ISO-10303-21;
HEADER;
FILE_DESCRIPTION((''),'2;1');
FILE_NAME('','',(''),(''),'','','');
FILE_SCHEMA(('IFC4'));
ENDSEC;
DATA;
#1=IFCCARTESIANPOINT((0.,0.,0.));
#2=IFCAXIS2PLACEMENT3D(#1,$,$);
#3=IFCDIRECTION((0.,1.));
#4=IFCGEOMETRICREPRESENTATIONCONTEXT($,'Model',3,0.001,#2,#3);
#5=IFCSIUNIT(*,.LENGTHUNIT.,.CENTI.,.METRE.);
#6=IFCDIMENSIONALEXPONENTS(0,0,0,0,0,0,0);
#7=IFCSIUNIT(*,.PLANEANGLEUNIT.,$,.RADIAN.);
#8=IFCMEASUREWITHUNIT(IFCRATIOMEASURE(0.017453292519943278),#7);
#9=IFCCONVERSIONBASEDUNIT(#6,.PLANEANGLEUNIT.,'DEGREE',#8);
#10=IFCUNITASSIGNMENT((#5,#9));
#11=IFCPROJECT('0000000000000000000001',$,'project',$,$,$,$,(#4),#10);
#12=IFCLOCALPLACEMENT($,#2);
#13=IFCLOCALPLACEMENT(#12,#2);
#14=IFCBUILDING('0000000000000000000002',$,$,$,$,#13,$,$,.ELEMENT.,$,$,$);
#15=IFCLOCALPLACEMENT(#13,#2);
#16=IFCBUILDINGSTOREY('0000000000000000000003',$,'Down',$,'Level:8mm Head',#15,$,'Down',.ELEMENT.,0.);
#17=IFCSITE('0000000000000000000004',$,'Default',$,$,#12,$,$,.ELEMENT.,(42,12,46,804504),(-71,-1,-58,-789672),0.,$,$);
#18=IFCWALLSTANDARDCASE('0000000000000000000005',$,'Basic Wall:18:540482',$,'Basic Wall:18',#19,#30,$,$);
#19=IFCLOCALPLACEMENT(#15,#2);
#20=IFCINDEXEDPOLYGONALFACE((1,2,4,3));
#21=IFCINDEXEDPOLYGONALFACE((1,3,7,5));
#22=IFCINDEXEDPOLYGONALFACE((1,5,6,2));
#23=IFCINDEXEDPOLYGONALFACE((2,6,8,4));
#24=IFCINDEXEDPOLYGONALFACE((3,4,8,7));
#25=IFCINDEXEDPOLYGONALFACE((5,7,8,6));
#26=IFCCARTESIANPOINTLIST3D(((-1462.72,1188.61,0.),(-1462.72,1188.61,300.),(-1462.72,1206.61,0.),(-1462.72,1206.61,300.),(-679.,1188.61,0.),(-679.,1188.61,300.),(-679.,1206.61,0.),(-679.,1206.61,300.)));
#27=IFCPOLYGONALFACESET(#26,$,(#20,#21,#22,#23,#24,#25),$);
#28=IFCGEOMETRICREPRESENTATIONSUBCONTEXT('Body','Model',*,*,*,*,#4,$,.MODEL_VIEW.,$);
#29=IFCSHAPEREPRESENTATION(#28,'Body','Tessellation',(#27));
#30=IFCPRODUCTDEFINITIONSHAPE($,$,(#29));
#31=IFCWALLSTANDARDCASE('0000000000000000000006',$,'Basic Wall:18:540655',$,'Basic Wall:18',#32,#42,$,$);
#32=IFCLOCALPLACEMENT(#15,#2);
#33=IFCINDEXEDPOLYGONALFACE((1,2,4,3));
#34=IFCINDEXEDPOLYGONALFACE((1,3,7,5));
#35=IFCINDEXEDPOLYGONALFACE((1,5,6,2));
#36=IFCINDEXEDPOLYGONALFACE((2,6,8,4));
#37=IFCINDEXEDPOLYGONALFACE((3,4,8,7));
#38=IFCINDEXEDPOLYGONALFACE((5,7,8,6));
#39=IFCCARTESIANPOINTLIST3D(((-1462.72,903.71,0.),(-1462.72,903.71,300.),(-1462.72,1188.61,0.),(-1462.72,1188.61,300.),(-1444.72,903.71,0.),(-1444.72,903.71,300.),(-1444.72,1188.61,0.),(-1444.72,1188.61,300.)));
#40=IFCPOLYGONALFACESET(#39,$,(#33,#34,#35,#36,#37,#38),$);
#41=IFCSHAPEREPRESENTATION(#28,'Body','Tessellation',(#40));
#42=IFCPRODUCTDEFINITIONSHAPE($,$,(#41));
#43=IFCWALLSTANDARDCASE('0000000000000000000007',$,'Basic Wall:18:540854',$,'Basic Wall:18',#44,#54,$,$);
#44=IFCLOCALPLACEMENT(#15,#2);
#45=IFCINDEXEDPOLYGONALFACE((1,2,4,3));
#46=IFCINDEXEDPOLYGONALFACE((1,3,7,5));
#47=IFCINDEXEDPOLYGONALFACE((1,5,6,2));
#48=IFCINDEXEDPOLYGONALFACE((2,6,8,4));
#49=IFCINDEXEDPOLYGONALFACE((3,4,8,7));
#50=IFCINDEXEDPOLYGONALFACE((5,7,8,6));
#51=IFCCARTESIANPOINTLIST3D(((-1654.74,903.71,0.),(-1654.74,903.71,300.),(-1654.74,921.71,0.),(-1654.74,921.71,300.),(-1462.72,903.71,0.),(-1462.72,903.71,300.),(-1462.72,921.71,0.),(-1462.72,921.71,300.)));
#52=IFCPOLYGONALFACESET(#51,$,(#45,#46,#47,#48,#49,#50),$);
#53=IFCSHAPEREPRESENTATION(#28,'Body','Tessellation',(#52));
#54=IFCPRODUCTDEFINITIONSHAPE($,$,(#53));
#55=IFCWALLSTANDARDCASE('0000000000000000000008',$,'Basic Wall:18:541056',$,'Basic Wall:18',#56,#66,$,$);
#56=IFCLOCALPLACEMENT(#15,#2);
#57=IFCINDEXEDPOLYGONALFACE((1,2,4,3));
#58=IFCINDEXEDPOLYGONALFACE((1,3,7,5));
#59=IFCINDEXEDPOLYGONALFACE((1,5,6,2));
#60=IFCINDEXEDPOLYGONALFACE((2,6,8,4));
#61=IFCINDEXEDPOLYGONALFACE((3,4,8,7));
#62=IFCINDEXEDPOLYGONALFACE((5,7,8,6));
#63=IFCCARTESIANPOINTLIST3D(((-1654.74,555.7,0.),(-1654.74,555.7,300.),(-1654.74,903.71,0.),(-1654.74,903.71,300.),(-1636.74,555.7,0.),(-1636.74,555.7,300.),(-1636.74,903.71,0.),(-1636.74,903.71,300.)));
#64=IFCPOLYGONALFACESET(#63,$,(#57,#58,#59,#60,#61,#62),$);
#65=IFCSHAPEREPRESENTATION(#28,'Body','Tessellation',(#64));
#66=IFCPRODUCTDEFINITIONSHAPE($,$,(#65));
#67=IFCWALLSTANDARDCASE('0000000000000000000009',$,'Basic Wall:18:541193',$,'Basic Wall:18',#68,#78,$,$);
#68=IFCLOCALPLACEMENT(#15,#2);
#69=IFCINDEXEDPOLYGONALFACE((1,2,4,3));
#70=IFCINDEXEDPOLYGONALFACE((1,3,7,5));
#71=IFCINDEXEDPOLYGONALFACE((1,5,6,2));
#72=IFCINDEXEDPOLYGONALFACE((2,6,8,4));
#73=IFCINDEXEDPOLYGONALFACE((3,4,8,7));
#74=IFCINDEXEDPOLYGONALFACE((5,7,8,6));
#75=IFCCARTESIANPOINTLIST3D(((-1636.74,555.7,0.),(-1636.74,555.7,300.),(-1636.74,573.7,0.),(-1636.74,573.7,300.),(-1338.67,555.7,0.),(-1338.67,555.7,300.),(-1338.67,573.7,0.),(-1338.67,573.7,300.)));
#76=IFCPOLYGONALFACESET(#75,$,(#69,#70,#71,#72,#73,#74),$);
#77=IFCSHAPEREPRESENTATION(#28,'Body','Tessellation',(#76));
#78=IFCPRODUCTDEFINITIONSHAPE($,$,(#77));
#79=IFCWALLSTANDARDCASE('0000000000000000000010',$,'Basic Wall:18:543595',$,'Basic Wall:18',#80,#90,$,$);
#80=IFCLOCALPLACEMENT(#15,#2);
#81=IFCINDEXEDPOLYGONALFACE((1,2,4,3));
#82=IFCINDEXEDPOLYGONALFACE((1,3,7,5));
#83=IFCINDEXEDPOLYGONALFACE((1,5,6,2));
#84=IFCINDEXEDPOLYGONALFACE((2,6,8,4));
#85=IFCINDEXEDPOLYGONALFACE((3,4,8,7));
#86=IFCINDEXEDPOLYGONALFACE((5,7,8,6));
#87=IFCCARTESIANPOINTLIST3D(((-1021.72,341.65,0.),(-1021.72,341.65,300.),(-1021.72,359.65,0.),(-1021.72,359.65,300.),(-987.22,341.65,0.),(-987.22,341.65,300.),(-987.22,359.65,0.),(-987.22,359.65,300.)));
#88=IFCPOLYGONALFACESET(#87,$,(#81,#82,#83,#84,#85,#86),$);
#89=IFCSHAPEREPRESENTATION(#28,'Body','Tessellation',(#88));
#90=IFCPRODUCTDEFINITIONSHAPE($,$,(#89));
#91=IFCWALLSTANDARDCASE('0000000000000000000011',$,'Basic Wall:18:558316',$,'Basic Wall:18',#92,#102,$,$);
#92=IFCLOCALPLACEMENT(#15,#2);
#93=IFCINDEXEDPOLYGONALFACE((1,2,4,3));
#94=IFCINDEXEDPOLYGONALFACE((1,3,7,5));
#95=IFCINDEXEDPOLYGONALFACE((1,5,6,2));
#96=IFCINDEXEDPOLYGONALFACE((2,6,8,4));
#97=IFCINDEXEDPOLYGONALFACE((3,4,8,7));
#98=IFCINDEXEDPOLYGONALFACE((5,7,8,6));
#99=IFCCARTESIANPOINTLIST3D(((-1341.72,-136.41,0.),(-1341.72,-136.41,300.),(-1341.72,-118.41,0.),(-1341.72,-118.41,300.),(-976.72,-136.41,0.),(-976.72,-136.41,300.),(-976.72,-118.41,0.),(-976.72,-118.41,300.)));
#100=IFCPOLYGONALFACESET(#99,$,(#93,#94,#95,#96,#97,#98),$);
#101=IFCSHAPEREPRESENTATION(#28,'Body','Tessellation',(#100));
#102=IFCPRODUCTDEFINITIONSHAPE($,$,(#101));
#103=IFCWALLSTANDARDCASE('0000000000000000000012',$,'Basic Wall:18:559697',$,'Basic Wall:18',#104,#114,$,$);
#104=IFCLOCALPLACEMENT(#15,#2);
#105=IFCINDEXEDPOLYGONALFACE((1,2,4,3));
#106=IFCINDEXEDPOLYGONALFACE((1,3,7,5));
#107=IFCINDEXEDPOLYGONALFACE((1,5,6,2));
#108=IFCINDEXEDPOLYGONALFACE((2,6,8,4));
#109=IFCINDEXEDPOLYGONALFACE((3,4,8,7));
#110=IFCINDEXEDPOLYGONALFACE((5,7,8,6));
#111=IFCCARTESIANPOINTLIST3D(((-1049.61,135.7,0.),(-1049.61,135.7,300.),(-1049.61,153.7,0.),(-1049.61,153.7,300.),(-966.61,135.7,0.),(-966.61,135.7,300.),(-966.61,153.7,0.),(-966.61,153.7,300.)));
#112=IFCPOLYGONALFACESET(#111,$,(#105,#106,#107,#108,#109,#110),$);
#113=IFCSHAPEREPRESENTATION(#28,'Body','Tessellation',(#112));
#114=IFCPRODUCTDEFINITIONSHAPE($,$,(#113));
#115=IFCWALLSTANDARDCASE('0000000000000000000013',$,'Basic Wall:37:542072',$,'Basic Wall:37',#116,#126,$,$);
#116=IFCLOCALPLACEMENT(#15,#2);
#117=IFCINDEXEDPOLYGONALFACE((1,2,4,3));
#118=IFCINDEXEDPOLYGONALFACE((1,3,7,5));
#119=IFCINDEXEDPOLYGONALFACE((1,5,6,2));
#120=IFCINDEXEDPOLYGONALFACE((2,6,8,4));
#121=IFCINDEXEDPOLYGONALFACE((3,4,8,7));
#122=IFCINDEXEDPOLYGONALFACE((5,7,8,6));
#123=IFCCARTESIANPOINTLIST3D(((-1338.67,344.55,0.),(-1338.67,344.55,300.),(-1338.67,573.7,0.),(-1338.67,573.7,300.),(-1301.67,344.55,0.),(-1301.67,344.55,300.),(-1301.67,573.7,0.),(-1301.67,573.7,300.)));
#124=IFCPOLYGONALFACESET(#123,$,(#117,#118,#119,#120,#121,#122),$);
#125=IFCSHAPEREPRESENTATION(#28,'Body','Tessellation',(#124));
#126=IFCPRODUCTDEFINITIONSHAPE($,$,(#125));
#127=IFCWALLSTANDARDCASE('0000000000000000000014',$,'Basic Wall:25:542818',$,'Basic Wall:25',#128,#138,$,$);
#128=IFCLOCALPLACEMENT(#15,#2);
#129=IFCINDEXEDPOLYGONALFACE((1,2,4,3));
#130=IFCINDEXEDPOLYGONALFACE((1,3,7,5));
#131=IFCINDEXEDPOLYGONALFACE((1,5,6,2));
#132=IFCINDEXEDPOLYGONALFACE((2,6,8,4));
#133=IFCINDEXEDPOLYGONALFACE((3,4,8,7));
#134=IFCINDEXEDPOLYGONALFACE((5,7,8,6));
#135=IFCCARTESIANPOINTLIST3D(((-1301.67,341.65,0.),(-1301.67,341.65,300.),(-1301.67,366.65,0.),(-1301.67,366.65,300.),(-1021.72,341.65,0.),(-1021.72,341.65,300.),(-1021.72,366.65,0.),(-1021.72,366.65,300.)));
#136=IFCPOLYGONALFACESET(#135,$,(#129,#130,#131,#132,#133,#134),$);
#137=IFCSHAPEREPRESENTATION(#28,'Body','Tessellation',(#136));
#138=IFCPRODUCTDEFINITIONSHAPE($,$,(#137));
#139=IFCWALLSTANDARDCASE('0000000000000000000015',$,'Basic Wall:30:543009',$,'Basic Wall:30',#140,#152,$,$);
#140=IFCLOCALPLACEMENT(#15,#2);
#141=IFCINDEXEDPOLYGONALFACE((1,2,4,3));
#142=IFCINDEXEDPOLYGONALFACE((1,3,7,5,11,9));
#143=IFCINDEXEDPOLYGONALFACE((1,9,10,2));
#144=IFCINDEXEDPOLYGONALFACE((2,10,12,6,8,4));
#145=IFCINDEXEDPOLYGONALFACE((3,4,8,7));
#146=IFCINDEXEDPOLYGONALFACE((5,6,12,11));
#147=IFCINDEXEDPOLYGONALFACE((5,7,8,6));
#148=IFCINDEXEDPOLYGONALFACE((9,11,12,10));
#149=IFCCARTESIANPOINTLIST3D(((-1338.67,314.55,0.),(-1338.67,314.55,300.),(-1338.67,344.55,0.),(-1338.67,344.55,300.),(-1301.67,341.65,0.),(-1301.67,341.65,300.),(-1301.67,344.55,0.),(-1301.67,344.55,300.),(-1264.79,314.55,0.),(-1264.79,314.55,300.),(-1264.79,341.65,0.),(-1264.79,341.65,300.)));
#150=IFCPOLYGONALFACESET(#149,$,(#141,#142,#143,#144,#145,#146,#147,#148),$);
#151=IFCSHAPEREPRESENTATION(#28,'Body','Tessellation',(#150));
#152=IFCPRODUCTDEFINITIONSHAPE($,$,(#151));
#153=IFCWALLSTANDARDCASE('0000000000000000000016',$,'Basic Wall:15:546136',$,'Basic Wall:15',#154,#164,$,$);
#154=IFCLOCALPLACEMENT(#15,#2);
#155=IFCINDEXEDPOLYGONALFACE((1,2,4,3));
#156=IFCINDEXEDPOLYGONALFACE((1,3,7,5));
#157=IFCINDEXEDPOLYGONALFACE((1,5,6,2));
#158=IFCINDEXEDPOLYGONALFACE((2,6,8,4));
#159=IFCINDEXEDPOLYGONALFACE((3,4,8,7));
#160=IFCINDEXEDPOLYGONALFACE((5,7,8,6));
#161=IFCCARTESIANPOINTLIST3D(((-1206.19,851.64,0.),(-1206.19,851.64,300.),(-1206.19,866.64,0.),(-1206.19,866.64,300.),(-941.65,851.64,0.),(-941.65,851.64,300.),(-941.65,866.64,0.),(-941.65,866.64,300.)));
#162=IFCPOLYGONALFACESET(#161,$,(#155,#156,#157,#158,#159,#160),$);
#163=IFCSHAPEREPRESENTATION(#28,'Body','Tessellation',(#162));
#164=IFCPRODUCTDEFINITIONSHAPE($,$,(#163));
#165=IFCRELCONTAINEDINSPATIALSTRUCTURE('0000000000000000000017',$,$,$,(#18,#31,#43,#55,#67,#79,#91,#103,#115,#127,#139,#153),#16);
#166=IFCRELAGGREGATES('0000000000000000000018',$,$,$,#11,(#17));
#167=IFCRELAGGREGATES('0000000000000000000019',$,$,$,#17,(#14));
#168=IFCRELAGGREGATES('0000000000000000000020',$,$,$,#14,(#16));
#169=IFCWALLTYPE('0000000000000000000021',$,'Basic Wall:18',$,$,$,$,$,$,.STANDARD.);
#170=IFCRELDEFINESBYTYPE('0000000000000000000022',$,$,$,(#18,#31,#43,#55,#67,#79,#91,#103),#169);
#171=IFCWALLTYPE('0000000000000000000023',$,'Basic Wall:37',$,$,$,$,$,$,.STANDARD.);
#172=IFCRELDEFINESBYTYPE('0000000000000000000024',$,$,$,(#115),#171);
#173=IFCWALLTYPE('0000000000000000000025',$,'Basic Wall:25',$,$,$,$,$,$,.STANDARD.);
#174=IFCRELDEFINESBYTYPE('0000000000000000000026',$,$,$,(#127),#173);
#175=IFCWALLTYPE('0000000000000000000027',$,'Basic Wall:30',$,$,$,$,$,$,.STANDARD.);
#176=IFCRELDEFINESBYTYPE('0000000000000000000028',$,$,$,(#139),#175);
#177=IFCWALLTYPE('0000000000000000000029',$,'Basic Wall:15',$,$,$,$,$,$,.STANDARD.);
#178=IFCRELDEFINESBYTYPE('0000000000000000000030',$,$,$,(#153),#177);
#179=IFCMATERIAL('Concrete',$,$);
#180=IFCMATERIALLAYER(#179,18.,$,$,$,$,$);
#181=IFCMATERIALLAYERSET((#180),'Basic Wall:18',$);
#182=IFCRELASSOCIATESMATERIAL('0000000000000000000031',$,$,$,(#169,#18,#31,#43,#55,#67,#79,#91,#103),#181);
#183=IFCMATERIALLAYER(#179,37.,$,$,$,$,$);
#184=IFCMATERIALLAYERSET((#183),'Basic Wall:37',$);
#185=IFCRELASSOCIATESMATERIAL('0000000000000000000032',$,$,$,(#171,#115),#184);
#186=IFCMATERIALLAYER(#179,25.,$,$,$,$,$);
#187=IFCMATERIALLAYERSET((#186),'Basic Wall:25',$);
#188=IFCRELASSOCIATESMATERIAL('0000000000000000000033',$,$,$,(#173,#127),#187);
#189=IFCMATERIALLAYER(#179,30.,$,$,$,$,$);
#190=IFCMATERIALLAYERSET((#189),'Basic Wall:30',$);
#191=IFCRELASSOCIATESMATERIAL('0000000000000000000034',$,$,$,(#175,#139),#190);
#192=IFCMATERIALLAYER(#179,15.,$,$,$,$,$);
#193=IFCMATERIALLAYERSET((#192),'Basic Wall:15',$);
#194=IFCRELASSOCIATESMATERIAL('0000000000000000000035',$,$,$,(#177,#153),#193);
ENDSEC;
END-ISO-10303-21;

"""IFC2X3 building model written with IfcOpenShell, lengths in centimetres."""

from ifc_helpers import new_model, entity, si_unit, converted_unit, direction, frame, frame_2d, origin, place, context, subcontext, project, spatial, polyline, rectangle, extrude, clip, bounded_halfspace, material, layer, layer_set, layer_usage, type_object, element, save


model = new_model("IFC2X3")

# Units and contexts
model_context = context("Model", 3, precision=0.001, world=origin(), true_north=direction((0.0, 1.0)))
body_context = subcontext(model_context, "Body", "Model", "MODEL_VIEW")
ifc_project = project(units=[si_unit("LENGTHUNIT", "METRE", prefix="CENTI"), converted_unit("PLANEANGLEUNIT", "DEGREE", entity("IfcRatioMeasure", 0.017453292519943278), si_unit("PLANEANGLEUNIT", "RADIAN"), dimensions=[0, 0, 0, 0, 0, 0, 0])], contexts=[model_context])

# Site, building, storey
site_placement = place(None, origin())
site = spatial("IfcSite", under=ifc_project, at=site_placement, Name="Default", CompositionType="ELEMENT", RefLatitude=(42, 12, 46, 804504), RefLongitude=(-71, -1, -58, -789672), RefElevation=0.0)
building_placement = place(site_placement, origin())
building = spatial("IfcBuilding", under=site, at=building_placement, CompositionType="ELEMENT")
storey_placement = place(building_placement, origin())
storey = spatial("IfcBuildingStorey", under=building, at=storey_placement, Name="Down", ObjectType="Level:8mm Head", LongName="Down", CompositionType="ELEMENT", Elevation=0.0)

# Walls
ifc_material = material(Name="Concrete")
ifc_layer_1 = layer(ifc_material, 18.0)
ifc_layer_set_1 = layer_set([ifc_layer_1], Name="Basic Wall:18")
wall_type_1 = type_object("IfcWallType", Name="Basic Wall:18", PredefinedType="STANDARD", material=ifc_layer_set_1)
ifc_layer_usage_1 = layer_usage(ifc_layer_set_1, "AXIS2", "POSITIVE", -9.0)
wall_1_placement = place(storey_placement, frame((-679.0, 1197.61, 0.0), z_axis=(0.0, 0.0, 1.0), x_axis=(-1.0, 0.0, 0.0)))
element("IfcWallStandardCase", 1, at=wall_1_placement, inside=storey, type_object=wall_type_1, material=ifc_layer_usage_1, Name="Basic Wall:18:540482", ObjectType="Basic Wall:18", context=body_context, shape_type="SweptSolid", body=[
    extrude(rectangle(XDim=783.71, YDim=18.0, at=frame_2d((391.86, 0.0), x_axis=(-1.0, 0.0))), origin(), (0.0, 0.0, 1.0), 300.0),
])
ifc_layer_usage_2 = layer_usage(ifc_layer_set_1, "AXIS2", "POSITIVE", -9.0)
wall_2_placement = place(storey_placement, frame((-1453.72, 1188.61, 0.0), z_axis=(0.0, 0.0, 1.0), x_axis=(0.0, -1.0, 0.0)))
element("IfcWallStandardCase", 2, at=wall_2_placement, inside=storey, type_object=wall_type_1, material=ifc_layer_usage_2, Name="Basic Wall:18:540655", ObjectType="Basic Wall:18", context=body_context, shape_type="SweptSolid", body=[
    extrude(rectangle(XDim=284.9, YDim=18.0, at=frame_2d((142.45, 0.0), x_axis=(-1.0, 0.0))), origin(), (0.0, 0.0, 1.0), 300.0),
])
ifc_layer_usage_3 = layer_usage(ifc_layer_set_1, "AXIS2", "NEGATIVE", 9.0)
wall_3_placement = place(storey_placement, frame((-1462.72, 912.71, 0.0), z_axis=(0.0, 0.0, 1.0), x_axis=(-1.0, 0.0, 0.0)))
element("IfcWallStandardCase", 3, at=wall_3_placement, inside=storey, type_object=wall_type_1, material=ifc_layer_usage_3, Name="Basic Wall:18:540854", ObjectType="Basic Wall:18", context=body_context, shape_type="SweptSolid", body=[
    extrude(rectangle(XDim=192.03, YDim=18.0, at=frame_2d((96.01, 0.0), x_axis=(-1.0, 0.0))), origin(), (0.0, 0.0, 1.0), 300.0),
])
ifc_layer_usage_4 = layer_usage(ifc_layer_set_1, "AXIS2", "POSITIVE", -9.0)
wall_4_placement = place(storey_placement, frame((-1645.74, 903.71, 0.0), z_axis=(0.0, 0.0, 1.0), x_axis=(0.0, -1.0, 0.0)))
element("IfcWallStandardCase", 4, at=wall_4_placement, inside=storey, type_object=wall_type_1, material=ifc_layer_usage_4, Name="Basic Wall:18:541056", ObjectType="Basic Wall:18", context=body_context, shape_type="SweptSolid", body=[
    extrude(rectangle(XDim=348.01, YDim=18.0, at=frame_2d((174.01, 0.0), x_axis=(-1.0, 0.0))), origin(), (0.0, 0.0, 1.0), 300.0),
])
ifc_layer_usage_5 = layer_usage(ifc_layer_set_1, "AXIS2", "POSITIVE", -9.0)
wall_5_placement = place(storey_placement, frame((-1636.74, 564.7, 0.0)))
element("IfcWallStandardCase", 5, at=wall_5_placement, inside=storey, type_object=wall_type_1, material=ifc_layer_usage_5, Name="Basic Wall:18:541193", ObjectType="Basic Wall:18", context=body_context, shape_type="SweptSolid", body=[
    extrude(rectangle(XDim=298.07, YDim=18.0, at=frame_2d((149.04, 0.0), x_axis=(-1.0, 0.0))), origin(), (0.0, 0.0, 1.0), 300.0),
])
ifc_layer_usage_6 = layer_usage(ifc_layer_set_1, "AXIS2", "POSITIVE", -9.0)
wall_6_placement = place(storey_placement, frame((-1021.72, 350.65, 0.0)))
element("IfcWallStandardCase", 6, at=wall_6_placement, inside=storey, type_object=wall_type_1, material=ifc_layer_usage_6, Name="Basic Wall:18:543595", ObjectType="Basic Wall:18", context=body_context, shape_type="SweptSolid", body=[
    extrude(rectangle(XDim=34.5, YDim=18.0, at=frame_2d((17.25, 0.0), x_axis=(-1.0, 0.0))), origin(), (0.0, 0.0, 1.0), 300.0),
])
ifc_layer_usage_7 = layer_usage(ifc_layer_set_1, "AXIS2", "NEGATIVE", 9.0)
wall_7_placement = place(storey_placement, frame((-1341.72, -127.41, 0.0)))
element("IfcWallStandardCase", 7, at=wall_7_placement, inside=storey, type_object=wall_type_1, material=ifc_layer_usage_7, Name="Basic Wall:18:558316", ObjectType="Basic Wall:18", context=body_context, shape_type="SweptSolid", body=[
    extrude(rectangle(XDim=365.0, YDim=18.0, at=frame_2d((182.5, 0.0), x_axis=(-1.0, 0.0))), origin(), (0.0, 0.0, 1.0), 300.0),
])
ifc_layer_usage_8 = layer_usage(ifc_layer_set_1, "AXIS2", "POSITIVE", -9.0)
wall_8_placement = place(storey_placement, frame((-966.61, 144.7, 0.0), z_axis=(0.0, 0.0, 1.0), x_axis=(-1.0, 0.0, 0.0)))
element("IfcWallStandardCase", 8, at=wall_8_placement, inside=storey, type_object=wall_type_1, material=ifc_layer_usage_8, Name="Basic Wall:18:559697", ObjectType="Basic Wall:18", context=body_context, shape_type="SweptSolid", body=[
    extrude(rectangle(XDim=83.0, YDim=18.0, at=frame_2d((41.5, 0.0), x_axis=(-1.0, 0.0))), origin(), (0.0, 0.0, 1.0), 300.0),
])
ifc_layer_2 = layer(ifc_material, 37.0)
ifc_layer_set_2 = layer_set([ifc_layer_2], Name="Basic Wall:37")
ifc_layer_usage_9 = layer_usage(ifc_layer_set_2, "AXIS2", "NEGATIVE", 18.5)
wall_type_2 = type_object("IfcWallType", Name="Basic Wall:37", PredefinedType="STANDARD", material=ifc_layer_set_2)
wall_9_placement = place(storey_placement, frame((-1320.17, 573.7, 0.0), z_axis=(0.0, 0.0, 1.0), x_axis=(0.0, -1.0, 0.0)))
element("IfcWallStandardCase", 9, at=wall_9_placement, inside=storey, type_object=wall_type_2, material=ifc_layer_usage_9, Name="Basic Wall:37:542072", ObjectType="Basic Wall:37", context=body_context, shape_type="SweptSolid", body=[
    extrude(rectangle(XDim=229.14, YDim=37.0, at=frame_2d((114.57, 0.0), x_axis=(-1.0, 0.0))), origin(), (0.0, 0.0, 1.0), 300.0),
])
ifc_layer_3 = layer(ifc_material, 25.0)
ifc_layer_set_3 = layer_set([ifc_layer_3], Name="Basic Wall:25")
ifc_layer_usage_10 = layer_usage(ifc_layer_set_3, "AXIS2", "POSITIVE", -12.5)
wall_type_3 = type_object("IfcWallType", Name="Basic Wall:25", PredefinedType="STANDARD", material=ifc_layer_set_3)
wall_10_placement = place(storey_placement, frame((-1021.72, 354.15, 0.0), z_axis=(0.0, 0.0, 1.0), x_axis=(-1.0, 0.0, 0.0)))
element("IfcWallStandardCase", 10, at=wall_10_placement, inside=storey, type_object=wall_type_3, material=ifc_layer_usage_10, Name="Basic Wall:25:542818", ObjectType="Basic Wall:25", context=body_context, shape_type="SweptSolid", body=[
    extrude(rectangle(XDim=279.95, YDim=25.0, at=frame_2d((139.98, 0.0), x_axis=(-1.0, 0.0))), origin(), (0.0, 0.0, 1.0), 300.0),
])
ifc_layer_4 = layer(ifc_material, 30.0)
ifc_layer_set_4 = layer_set([ifc_layer_4], Name="Basic Wall:30")
ifc_layer_usage_11 = layer_usage(ifc_layer_set_4, "AXIS2", "NEGATIVE", 15.0)
wall_type_4 = type_object("IfcWallType", Name="Basic Wall:30", PredefinedType="STANDARD", material=ifc_layer_set_4)
wall_11_placement = place(storey_placement, frame((-1264.79, 329.55, 0.0), z_axis=(0.0, 0.0, 1.0), x_axis=(-1.0, 0.0, 0.0)))
element("IfcWallStandardCase", 11, at=wall_11_placement, inside=storey, type_object=wall_type_4, material=ifc_layer_usage_11, Name="Basic Wall:30:543009", ObjectType="Basic Wall:30", context=body_context, shape_type="Clipping", body=[
    clip(clip(extrude(rectangle(XDim=73.89, YDim=30.0, at=frame_2d((36.94, 0.0), x_axis=(-1.0, 0.0))), origin(), (0.0, 0.0, 1.0), 300.0), bounded_halfspace(frame((36.89, -12.09, 0.0), z_axis=(0.0, 1.0, 0.0), x_axis=(-1.0, 0.0, 0.0)), True, frame((36.89, -12.09, 0.0), z_axis=(0.0, 1.0, 0.0), x_axis=(-1.0, 0.0, 0.0)), polyline([(0.0, 0.0), (36.89, 0.0), (36.89, 300.0), (0.0, 300.0), (0.0, 0.0)]))), bounded_halfspace(frame((36.89, -12.09, 300.0), z_axis=(-1.0, 0.0, 0.0), x_axis=(0.0, -1.0, 0.0)), False, frame((36.89, -12.09, 300.0), z_axis=(-1.0, 0.0, 0.0), x_axis=(0.0, -1.0, 0.0)), polyline([(0.0, 0.0), (0.0, -300.0), (2.91, -300.0), (2.91, 0.0), (0.0, 0.0)]))),
])
ifc_layer_5 = layer(ifc_material, 15.0)
ifc_layer_set_5 = layer_set([ifc_layer_5], Name="Basic Wall:15")
ifc_layer_usage_12 = layer_usage(ifc_layer_set_5, "AXIS2", "POSITIVE", -7.5)
wall_type_5 = type_object("IfcWallType", Name="Basic Wall:15", PredefinedType="STANDARD", material=ifc_layer_set_5)
wall_12_placement = place(storey_placement, frame((-1206.19, 859.14, 0.0)))
element("IfcWallStandardCase", 12, at=wall_12_placement, inside=storey, type_object=wall_type_5, material=ifc_layer_usage_12, Name="Basic Wall:15:546136", ObjectType="Basic Wall:15", context=body_context, shape_type="SweptSolid", body=[
    extrude(rectangle(XDim=264.54, YDim=15.0, at=frame_2d((132.27, 0.0), x_axis=(-1.0, 0.0))), origin(), (0.0, 0.0, 1.0), 300.0),
])

save(model, "model.ifc")
